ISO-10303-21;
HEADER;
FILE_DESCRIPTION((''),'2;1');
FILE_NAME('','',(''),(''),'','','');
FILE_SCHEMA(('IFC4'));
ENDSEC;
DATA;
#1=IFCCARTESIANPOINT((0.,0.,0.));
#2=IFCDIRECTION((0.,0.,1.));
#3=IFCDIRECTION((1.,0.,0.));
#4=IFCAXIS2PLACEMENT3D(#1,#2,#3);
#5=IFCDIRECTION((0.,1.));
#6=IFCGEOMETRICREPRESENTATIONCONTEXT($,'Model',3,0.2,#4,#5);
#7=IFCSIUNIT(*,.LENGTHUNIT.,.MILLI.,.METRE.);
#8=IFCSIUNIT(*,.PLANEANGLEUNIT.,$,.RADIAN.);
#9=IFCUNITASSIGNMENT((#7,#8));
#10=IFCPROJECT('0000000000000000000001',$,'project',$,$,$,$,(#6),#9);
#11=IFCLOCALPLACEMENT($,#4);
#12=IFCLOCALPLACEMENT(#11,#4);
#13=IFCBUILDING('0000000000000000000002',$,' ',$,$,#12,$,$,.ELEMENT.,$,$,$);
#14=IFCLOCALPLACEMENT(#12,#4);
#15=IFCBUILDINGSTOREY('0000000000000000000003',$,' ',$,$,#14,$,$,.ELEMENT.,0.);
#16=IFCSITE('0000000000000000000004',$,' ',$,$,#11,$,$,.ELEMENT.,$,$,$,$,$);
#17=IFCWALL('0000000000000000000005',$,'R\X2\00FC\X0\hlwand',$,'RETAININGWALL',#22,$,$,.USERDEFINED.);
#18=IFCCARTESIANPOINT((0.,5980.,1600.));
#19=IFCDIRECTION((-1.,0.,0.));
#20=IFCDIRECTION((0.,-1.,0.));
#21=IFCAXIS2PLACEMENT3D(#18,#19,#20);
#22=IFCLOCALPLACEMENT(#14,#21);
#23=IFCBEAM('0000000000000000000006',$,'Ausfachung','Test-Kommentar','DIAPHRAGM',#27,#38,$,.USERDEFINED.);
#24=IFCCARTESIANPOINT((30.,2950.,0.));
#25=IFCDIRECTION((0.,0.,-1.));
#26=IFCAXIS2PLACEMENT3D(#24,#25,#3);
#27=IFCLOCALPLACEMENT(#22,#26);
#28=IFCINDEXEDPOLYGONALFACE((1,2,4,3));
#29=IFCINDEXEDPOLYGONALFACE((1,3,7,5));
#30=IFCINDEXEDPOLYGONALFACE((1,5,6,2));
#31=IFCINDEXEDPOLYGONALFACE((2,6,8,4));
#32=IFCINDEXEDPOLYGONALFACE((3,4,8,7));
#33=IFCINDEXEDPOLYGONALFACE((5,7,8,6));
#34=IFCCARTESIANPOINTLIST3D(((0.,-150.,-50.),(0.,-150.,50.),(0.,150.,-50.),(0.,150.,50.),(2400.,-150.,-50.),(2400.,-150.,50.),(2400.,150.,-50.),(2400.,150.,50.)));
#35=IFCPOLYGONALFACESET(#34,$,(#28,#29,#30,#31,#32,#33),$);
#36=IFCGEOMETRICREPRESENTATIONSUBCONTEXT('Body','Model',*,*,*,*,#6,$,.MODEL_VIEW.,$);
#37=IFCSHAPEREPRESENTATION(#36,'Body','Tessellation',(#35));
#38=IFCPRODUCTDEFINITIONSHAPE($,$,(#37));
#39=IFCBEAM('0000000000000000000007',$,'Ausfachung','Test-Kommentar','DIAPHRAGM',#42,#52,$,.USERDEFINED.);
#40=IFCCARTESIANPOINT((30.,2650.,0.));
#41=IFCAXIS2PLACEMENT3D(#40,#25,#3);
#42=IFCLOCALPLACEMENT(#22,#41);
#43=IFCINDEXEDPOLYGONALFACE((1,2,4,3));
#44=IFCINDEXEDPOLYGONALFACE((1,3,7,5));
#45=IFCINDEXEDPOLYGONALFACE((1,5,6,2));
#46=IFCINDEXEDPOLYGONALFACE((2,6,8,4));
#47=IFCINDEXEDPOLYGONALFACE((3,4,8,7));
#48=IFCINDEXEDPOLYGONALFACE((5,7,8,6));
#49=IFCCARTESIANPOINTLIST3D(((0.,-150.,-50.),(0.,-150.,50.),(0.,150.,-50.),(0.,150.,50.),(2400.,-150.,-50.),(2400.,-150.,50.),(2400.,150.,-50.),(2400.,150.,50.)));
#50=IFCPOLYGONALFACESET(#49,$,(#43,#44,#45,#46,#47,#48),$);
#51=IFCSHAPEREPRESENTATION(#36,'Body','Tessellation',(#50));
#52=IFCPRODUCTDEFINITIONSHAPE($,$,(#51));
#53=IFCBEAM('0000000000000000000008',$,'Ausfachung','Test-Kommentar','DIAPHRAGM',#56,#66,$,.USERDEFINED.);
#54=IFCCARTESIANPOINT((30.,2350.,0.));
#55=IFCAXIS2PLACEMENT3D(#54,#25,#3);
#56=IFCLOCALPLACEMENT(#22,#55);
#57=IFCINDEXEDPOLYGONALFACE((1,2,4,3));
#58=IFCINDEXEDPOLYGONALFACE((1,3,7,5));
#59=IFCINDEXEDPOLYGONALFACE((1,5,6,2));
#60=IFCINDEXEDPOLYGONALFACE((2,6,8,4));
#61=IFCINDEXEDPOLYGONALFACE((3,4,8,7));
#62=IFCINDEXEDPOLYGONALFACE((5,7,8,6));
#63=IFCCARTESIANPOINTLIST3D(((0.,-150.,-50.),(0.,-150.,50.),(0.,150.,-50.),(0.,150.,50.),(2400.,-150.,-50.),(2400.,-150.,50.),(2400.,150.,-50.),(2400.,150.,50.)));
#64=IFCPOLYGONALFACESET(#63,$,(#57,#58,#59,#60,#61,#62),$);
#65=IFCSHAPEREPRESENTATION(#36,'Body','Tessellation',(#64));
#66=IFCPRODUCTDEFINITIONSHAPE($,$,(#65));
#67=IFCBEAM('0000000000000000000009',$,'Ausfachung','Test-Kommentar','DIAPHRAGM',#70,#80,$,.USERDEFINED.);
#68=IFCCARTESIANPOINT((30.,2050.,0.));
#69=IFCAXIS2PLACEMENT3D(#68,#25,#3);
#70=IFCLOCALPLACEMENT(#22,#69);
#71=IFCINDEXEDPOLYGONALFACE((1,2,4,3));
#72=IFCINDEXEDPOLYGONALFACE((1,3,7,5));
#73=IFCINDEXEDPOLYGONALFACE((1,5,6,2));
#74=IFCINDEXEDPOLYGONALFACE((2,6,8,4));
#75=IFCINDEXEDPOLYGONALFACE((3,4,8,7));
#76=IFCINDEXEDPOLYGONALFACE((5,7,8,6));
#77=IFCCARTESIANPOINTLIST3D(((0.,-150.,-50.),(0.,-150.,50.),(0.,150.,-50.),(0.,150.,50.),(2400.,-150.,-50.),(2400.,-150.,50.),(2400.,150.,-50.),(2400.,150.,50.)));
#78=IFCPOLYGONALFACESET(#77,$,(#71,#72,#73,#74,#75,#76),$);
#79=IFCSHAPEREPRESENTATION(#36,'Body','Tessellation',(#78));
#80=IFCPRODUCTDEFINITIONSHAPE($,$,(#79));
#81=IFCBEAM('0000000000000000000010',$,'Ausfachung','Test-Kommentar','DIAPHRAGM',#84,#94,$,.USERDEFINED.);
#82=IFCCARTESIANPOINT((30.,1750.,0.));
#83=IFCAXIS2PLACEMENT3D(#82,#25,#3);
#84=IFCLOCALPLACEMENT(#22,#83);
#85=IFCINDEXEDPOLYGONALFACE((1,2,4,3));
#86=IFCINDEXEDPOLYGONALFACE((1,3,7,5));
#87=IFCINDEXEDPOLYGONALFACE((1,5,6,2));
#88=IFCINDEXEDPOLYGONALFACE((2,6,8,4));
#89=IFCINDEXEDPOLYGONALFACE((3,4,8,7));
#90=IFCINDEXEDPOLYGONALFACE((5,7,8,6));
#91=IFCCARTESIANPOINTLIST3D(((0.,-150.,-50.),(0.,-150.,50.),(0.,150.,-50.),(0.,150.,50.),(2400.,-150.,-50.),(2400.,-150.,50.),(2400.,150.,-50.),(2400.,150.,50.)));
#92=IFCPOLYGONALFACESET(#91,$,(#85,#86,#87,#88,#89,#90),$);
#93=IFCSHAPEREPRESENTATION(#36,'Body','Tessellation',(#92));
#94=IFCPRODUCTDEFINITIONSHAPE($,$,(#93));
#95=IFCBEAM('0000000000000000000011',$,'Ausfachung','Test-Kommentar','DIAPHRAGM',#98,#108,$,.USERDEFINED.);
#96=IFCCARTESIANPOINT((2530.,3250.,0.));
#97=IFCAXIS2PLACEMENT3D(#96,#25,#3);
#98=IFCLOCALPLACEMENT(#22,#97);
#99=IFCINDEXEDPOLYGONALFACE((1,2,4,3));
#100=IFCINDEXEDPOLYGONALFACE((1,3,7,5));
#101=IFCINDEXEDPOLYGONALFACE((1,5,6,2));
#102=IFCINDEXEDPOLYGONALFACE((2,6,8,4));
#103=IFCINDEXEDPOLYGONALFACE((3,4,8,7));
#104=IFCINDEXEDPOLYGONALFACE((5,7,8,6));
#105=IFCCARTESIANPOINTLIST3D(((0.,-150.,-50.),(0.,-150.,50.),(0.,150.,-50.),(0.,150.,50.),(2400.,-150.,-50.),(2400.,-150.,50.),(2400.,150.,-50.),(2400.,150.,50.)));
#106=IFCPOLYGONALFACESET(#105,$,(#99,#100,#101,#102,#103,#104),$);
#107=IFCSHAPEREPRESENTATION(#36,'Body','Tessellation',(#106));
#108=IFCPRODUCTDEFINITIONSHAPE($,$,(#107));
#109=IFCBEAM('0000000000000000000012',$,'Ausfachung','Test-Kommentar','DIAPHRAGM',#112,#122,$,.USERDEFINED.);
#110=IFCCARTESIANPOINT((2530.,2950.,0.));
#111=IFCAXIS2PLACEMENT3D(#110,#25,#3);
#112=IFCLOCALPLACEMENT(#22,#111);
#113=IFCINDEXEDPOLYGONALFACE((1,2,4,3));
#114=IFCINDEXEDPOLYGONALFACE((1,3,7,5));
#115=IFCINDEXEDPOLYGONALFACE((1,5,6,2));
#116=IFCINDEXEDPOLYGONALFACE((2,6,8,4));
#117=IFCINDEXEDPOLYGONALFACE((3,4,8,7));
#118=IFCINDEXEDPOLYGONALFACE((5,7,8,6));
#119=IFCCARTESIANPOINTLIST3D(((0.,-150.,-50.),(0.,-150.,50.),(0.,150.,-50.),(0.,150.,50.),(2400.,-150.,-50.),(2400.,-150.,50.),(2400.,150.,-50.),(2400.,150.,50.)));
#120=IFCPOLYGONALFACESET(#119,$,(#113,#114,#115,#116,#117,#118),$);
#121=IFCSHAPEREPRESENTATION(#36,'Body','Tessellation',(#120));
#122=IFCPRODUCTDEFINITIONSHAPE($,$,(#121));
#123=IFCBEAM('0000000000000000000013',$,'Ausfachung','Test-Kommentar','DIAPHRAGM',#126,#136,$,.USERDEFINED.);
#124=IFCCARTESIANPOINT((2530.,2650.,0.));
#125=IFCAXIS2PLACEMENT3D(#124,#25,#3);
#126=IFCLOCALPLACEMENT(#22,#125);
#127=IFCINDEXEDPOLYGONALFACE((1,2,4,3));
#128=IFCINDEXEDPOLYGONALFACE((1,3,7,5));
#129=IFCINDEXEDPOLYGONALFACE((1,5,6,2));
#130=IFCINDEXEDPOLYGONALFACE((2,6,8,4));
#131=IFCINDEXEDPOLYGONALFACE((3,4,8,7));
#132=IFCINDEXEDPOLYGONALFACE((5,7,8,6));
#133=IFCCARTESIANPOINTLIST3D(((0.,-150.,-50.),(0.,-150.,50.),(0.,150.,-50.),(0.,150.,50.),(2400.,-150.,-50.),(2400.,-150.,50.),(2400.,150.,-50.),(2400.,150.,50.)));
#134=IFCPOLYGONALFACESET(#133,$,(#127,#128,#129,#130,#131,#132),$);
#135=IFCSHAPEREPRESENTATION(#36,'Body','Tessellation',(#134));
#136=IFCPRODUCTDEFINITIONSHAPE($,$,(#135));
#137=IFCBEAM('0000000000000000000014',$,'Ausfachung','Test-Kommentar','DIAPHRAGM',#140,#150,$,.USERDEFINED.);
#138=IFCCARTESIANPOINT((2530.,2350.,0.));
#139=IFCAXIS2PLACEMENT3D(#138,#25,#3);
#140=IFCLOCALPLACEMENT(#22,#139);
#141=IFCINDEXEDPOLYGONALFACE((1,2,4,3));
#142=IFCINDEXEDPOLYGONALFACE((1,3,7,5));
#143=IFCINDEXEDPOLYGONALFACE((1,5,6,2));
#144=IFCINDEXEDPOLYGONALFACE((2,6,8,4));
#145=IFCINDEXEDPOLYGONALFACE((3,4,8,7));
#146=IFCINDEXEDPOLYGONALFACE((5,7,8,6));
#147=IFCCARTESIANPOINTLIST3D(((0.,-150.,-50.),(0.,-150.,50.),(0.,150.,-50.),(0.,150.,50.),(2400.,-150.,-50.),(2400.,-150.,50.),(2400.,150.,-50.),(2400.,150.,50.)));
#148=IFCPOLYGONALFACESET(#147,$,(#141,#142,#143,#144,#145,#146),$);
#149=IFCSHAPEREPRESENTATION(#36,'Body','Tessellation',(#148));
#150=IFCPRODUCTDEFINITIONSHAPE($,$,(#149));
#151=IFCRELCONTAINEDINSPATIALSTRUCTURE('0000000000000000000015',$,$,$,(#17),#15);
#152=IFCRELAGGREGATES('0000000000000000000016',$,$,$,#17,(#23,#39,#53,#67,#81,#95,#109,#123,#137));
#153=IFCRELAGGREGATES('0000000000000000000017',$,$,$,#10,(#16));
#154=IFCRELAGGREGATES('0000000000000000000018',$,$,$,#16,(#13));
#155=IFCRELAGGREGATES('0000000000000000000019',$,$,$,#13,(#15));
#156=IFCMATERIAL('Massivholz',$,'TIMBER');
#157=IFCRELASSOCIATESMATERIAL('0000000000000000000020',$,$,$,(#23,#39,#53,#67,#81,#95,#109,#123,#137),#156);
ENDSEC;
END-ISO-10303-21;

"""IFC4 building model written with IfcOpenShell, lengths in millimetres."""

from ifc_helpers import new_model, si_unit, direction, frame, origin_with_axes, place, context, subcontext, project, spatial, line, indexed_curve, outline, extrude, material, element, aggregate, save


model = new_model("IFC4")

# Units and contexts
model_context = context("Model", 3, precision=0.2, world=origin_with_axes(), true_north=direction((0.0, 1.0)))
body_context = subcontext(model_context, "Body", "Model", "MODEL_VIEW")
ifc_project = project(units=[si_unit("LENGTHUNIT", "METRE", prefix="MILLI"), si_unit("PLANEANGLEUNIT", "RADIAN")], contexts=[model_context])

# Site, building, storey
site_placement = place(None, origin_with_axes())
site = spatial("IfcSite", under=ifc_project, at=site_placement, Name=" ", CompositionType="ELEMENT")
building_placement = place(site_placement, origin_with_axes())
building = spatial("IfcBuilding", under=site, at=building_placement, Name=" ", CompositionType="ELEMENT")
storey_placement = place(building_placement, origin_with_axes())
storey = spatial("IfcBuildingStorey", under=building, at=storey_placement, Name=" ", CompositionType="ELEMENT", Elevation=0.0)

# Wall, beams
wall_1_placement = place(storey_placement, frame((0.0, 5980.0, 1600.0), z_axis=(-1.0, 0.0, 0.0), x_axis=(0.0, -1.0, 0.0)))
wall_1 = element("IfcWall", 1, at=wall_1_placement, inside=storey, Name="Rühlwand", ObjectType="RETAININGWALL", PredefinedType="USERDEFINED")
ifc_material_1 = material(Name="Massivholz", Category="TIMBER")
beam_1_placement = place(wall_1_placement, frame((30.0, 2950.0, 0.0), z_axis=(0.0, 0.0, -1.0), x_axis=(1.0, 0.0, 0.0)))
beam_1 = element("IfcBeam", 2, at=beam_1_placement, material=ifc_material_1, Name="Ausfachung", Description="Test-Kommentar", ObjectType="DIAPHRAGM", PredefinedType="USERDEFINED", context=body_context, shape_type="SolidModel", body=[
    extrude(outline(indexed_curve([(-50.0, -150.0), (50.0, -150.0), (50.0, 150.0), (-50.0, 150.0)], segments=[line(1, 2, 3, 4, 1)])), frame((0.0, 0.0, 0.0), z_axis=(-1.0, 0.0, 0.0), x_axis=(0.0, 0.0, 1.0)), (0.0, 0.0, -1.0), 2400.0),
])
beam_2_placement = place(wall_1_placement, frame((30.0, 2650.0, 0.0), z_axis=(0.0, 0.0, -1.0), x_axis=(1.0, 0.0, 0.0)))
beam_2 = element("IfcBeam", 3, at=beam_2_placement, material=ifc_material_1, Name="Ausfachung", Description="Test-Kommentar", ObjectType="DIAPHRAGM", PredefinedType="USERDEFINED", context=body_context, shape_type="SolidModel", body=[
    extrude(outline(indexed_curve([(-50.0, -150.0), (50.0, -150.0), (50.0, 150.0), (-50.0, 150.0)], segments=[line(1, 2, 3, 4, 1)])), frame((0.0, 0.0, 0.0), z_axis=(-1.0, 0.0, 0.0), x_axis=(0.0, 0.0, 1.0)), (0.0, 0.0, -1.0), 2400.0),
])
beam_3_placement = place(wall_1_placement, frame((30.0, 2350.0, 0.0), z_axis=(0.0, 0.0, -1.0), x_axis=(1.0, 0.0, 0.0)))
beam_3 = element("IfcBeam", 4, at=beam_3_placement, material=ifc_material_1, Name="Ausfachung", Description="Test-Kommentar", ObjectType="DIAPHRAGM", PredefinedType="USERDEFINED", context=body_context, shape_type="SolidModel", body=[
    extrude(outline(indexed_curve([(-50.0, -150.0), (50.0, -150.0), (50.0, 150.0), (-50.0, 150.0)], segments=[line(1, 2, 3, 4, 1)])), frame((0.0, 0.0, 0.0), z_axis=(-1.0, 0.0, 0.0), x_axis=(0.0, 0.0, 1.0)), (0.0, 0.0, -1.0), 2400.0),
])
beam_4_placement = place(wall_1_placement, frame((30.0, 2050.0, 0.0), z_axis=(0.0, 0.0, -1.0), x_axis=(1.0, 0.0, 0.0)))
beam_4 = element("IfcBeam", 5, at=beam_4_placement, material=ifc_material_1, Name="Ausfachung", Description="Test-Kommentar", ObjectType="DIAPHRAGM", PredefinedType="USERDEFINED", context=body_context, shape_type="SolidModel", body=[
    extrude(outline(indexed_curve([(-50.0, -150.0), (50.0, -150.0), (50.0, 150.0), (-50.0, 150.0)], segments=[line(1, 2, 3, 4, 1)])), frame((0.0, 0.0, 0.0), z_axis=(-1.0, 0.0, 0.0), x_axis=(0.0, 0.0, 1.0)), (0.0, 0.0, -1.0), 2400.0),
])
beam_5_placement = place(wall_1_placement, frame((30.0, 1750.0, 0.0), z_axis=(0.0, 0.0, -1.0), x_axis=(1.0, 0.0, 0.0)))
beam_5 = element("IfcBeam", 6, at=beam_5_placement, material=ifc_material_1, Name="Ausfachung", Description="Test-Kommentar", ObjectType="DIAPHRAGM", PredefinedType="USERDEFINED", context=body_context, shape_type="SolidModel", body=[
    extrude(outline(indexed_curve([(-50.0, -150.0), (50.0, -150.0), (50.0, 150.0), (-50.0, 150.0)], segments=[line(1, 2, 3, 4, 1)])), frame((0.0, 0.0, 0.0), z_axis=(-1.0, 0.0, 0.0), x_axis=(0.0, 0.0, 1.0)), (0.0, 0.0, -1.0), 2400.0),
])
beam_6_placement = place(wall_1_placement, frame((2530.0, 3250.0, 0.0), z_axis=(0.0, 0.0, -1.0), x_axis=(1.0, 0.0, 0.0)))
beam_6 = element("IfcBeam", 7, at=beam_6_placement, material=ifc_material_1, Name="Ausfachung", Description="Test-Kommentar", ObjectType="DIAPHRAGM", PredefinedType="USERDEFINED", context=body_context, shape_type="SolidModel", body=[
    extrude(outline(indexed_curve([(-50.0, -150.0), (50.0, -150.0), (50.0, 150.0), (-50.0, 150.0)], segments=[line(1, 2, 3, 4, 1)])), frame((0.0, 0.0, 0.0), z_axis=(-1.0, 0.0, 0.0), x_axis=(0.0, 0.0, 1.0)), (0.0, 0.0, -1.0), 2400.0),
])
beam_7_placement = place(wall_1_placement, frame((2530.0, 2950.0, 0.0), z_axis=(0.0, 0.0, -1.0), x_axis=(1.0, 0.0, 0.0)))
beam_7 = element("IfcBeam", 8, at=beam_7_placement, material=ifc_material_1, Name="Ausfachung", Description="Test-Kommentar", ObjectType="DIAPHRAGM", PredefinedType="USERDEFINED", context=body_context, shape_type="SolidModel", body=[
    extrude(outline(indexed_curve([(-50.0, -150.0), (50.0, -150.0), (50.0, 150.0), (-50.0, 150.0)], segments=[line(1, 2, 3, 4, 1)])), frame((0.0, 0.0, 0.0), z_axis=(-1.0, 0.0, 0.0), x_axis=(0.0, 0.0, 1.0)), (0.0, 0.0, -1.0), 2400.0),
])
beam_8_placement = place(wall_1_placement, frame((2530.0, 2650.0, 0.0), z_axis=(0.0, 0.0, -1.0), x_axis=(1.0, 0.0, 0.0)))
beam_8 = element("IfcBeam", 9, at=beam_8_placement, material=ifc_material_1, Name="Ausfachung", Description="Test-Kommentar", ObjectType="DIAPHRAGM", PredefinedType="USERDEFINED", context=body_context, shape_type="SolidModel", body=[
    extrude(outline(indexed_curve([(-50.0, -150.0), (50.0, -150.0), (50.0, 150.0), (-50.0, 150.0)], segments=[line(1, 2, 3, 4, 1)])), frame((0.0, 0.0, 0.0), z_axis=(-1.0, 0.0, 0.0), x_axis=(0.0, 0.0, 1.0)), (0.0, 0.0, -1.0), 2400.0),
])
beam_9_placement = place(wall_1_placement, frame((2530.0, 2350.0, 0.0), z_axis=(0.0, 0.0, -1.0), x_axis=(1.0, 0.0, 0.0)))
beam_9 = element("IfcBeam", 10, at=beam_9_placement, material=ifc_material_1, Name="Ausfachung", Description="Test-Kommentar", ObjectType="DIAPHRAGM", PredefinedType="USERDEFINED", context=body_context, shape_type="SolidModel", body=[
    extrude(outline(indexed_curve([(-50.0, -150.0), (50.0, -150.0), (50.0, 150.0), (-50.0, 150.0)], segments=[line(1, 2, 3, 4, 1)])), frame((0.0, 0.0, 0.0), z_axis=(-1.0, 0.0, 0.0), x_axis=(0.0, 0.0, 1.0)), (0.0, 0.0, -1.0), 2400.0),
])

aggregate(wall_1, [beam_1, beam_2, beam_3, beam_4, beam_5, beam_6, beam_7, beam_8, beam_9])

save(model, "model.ifc")
